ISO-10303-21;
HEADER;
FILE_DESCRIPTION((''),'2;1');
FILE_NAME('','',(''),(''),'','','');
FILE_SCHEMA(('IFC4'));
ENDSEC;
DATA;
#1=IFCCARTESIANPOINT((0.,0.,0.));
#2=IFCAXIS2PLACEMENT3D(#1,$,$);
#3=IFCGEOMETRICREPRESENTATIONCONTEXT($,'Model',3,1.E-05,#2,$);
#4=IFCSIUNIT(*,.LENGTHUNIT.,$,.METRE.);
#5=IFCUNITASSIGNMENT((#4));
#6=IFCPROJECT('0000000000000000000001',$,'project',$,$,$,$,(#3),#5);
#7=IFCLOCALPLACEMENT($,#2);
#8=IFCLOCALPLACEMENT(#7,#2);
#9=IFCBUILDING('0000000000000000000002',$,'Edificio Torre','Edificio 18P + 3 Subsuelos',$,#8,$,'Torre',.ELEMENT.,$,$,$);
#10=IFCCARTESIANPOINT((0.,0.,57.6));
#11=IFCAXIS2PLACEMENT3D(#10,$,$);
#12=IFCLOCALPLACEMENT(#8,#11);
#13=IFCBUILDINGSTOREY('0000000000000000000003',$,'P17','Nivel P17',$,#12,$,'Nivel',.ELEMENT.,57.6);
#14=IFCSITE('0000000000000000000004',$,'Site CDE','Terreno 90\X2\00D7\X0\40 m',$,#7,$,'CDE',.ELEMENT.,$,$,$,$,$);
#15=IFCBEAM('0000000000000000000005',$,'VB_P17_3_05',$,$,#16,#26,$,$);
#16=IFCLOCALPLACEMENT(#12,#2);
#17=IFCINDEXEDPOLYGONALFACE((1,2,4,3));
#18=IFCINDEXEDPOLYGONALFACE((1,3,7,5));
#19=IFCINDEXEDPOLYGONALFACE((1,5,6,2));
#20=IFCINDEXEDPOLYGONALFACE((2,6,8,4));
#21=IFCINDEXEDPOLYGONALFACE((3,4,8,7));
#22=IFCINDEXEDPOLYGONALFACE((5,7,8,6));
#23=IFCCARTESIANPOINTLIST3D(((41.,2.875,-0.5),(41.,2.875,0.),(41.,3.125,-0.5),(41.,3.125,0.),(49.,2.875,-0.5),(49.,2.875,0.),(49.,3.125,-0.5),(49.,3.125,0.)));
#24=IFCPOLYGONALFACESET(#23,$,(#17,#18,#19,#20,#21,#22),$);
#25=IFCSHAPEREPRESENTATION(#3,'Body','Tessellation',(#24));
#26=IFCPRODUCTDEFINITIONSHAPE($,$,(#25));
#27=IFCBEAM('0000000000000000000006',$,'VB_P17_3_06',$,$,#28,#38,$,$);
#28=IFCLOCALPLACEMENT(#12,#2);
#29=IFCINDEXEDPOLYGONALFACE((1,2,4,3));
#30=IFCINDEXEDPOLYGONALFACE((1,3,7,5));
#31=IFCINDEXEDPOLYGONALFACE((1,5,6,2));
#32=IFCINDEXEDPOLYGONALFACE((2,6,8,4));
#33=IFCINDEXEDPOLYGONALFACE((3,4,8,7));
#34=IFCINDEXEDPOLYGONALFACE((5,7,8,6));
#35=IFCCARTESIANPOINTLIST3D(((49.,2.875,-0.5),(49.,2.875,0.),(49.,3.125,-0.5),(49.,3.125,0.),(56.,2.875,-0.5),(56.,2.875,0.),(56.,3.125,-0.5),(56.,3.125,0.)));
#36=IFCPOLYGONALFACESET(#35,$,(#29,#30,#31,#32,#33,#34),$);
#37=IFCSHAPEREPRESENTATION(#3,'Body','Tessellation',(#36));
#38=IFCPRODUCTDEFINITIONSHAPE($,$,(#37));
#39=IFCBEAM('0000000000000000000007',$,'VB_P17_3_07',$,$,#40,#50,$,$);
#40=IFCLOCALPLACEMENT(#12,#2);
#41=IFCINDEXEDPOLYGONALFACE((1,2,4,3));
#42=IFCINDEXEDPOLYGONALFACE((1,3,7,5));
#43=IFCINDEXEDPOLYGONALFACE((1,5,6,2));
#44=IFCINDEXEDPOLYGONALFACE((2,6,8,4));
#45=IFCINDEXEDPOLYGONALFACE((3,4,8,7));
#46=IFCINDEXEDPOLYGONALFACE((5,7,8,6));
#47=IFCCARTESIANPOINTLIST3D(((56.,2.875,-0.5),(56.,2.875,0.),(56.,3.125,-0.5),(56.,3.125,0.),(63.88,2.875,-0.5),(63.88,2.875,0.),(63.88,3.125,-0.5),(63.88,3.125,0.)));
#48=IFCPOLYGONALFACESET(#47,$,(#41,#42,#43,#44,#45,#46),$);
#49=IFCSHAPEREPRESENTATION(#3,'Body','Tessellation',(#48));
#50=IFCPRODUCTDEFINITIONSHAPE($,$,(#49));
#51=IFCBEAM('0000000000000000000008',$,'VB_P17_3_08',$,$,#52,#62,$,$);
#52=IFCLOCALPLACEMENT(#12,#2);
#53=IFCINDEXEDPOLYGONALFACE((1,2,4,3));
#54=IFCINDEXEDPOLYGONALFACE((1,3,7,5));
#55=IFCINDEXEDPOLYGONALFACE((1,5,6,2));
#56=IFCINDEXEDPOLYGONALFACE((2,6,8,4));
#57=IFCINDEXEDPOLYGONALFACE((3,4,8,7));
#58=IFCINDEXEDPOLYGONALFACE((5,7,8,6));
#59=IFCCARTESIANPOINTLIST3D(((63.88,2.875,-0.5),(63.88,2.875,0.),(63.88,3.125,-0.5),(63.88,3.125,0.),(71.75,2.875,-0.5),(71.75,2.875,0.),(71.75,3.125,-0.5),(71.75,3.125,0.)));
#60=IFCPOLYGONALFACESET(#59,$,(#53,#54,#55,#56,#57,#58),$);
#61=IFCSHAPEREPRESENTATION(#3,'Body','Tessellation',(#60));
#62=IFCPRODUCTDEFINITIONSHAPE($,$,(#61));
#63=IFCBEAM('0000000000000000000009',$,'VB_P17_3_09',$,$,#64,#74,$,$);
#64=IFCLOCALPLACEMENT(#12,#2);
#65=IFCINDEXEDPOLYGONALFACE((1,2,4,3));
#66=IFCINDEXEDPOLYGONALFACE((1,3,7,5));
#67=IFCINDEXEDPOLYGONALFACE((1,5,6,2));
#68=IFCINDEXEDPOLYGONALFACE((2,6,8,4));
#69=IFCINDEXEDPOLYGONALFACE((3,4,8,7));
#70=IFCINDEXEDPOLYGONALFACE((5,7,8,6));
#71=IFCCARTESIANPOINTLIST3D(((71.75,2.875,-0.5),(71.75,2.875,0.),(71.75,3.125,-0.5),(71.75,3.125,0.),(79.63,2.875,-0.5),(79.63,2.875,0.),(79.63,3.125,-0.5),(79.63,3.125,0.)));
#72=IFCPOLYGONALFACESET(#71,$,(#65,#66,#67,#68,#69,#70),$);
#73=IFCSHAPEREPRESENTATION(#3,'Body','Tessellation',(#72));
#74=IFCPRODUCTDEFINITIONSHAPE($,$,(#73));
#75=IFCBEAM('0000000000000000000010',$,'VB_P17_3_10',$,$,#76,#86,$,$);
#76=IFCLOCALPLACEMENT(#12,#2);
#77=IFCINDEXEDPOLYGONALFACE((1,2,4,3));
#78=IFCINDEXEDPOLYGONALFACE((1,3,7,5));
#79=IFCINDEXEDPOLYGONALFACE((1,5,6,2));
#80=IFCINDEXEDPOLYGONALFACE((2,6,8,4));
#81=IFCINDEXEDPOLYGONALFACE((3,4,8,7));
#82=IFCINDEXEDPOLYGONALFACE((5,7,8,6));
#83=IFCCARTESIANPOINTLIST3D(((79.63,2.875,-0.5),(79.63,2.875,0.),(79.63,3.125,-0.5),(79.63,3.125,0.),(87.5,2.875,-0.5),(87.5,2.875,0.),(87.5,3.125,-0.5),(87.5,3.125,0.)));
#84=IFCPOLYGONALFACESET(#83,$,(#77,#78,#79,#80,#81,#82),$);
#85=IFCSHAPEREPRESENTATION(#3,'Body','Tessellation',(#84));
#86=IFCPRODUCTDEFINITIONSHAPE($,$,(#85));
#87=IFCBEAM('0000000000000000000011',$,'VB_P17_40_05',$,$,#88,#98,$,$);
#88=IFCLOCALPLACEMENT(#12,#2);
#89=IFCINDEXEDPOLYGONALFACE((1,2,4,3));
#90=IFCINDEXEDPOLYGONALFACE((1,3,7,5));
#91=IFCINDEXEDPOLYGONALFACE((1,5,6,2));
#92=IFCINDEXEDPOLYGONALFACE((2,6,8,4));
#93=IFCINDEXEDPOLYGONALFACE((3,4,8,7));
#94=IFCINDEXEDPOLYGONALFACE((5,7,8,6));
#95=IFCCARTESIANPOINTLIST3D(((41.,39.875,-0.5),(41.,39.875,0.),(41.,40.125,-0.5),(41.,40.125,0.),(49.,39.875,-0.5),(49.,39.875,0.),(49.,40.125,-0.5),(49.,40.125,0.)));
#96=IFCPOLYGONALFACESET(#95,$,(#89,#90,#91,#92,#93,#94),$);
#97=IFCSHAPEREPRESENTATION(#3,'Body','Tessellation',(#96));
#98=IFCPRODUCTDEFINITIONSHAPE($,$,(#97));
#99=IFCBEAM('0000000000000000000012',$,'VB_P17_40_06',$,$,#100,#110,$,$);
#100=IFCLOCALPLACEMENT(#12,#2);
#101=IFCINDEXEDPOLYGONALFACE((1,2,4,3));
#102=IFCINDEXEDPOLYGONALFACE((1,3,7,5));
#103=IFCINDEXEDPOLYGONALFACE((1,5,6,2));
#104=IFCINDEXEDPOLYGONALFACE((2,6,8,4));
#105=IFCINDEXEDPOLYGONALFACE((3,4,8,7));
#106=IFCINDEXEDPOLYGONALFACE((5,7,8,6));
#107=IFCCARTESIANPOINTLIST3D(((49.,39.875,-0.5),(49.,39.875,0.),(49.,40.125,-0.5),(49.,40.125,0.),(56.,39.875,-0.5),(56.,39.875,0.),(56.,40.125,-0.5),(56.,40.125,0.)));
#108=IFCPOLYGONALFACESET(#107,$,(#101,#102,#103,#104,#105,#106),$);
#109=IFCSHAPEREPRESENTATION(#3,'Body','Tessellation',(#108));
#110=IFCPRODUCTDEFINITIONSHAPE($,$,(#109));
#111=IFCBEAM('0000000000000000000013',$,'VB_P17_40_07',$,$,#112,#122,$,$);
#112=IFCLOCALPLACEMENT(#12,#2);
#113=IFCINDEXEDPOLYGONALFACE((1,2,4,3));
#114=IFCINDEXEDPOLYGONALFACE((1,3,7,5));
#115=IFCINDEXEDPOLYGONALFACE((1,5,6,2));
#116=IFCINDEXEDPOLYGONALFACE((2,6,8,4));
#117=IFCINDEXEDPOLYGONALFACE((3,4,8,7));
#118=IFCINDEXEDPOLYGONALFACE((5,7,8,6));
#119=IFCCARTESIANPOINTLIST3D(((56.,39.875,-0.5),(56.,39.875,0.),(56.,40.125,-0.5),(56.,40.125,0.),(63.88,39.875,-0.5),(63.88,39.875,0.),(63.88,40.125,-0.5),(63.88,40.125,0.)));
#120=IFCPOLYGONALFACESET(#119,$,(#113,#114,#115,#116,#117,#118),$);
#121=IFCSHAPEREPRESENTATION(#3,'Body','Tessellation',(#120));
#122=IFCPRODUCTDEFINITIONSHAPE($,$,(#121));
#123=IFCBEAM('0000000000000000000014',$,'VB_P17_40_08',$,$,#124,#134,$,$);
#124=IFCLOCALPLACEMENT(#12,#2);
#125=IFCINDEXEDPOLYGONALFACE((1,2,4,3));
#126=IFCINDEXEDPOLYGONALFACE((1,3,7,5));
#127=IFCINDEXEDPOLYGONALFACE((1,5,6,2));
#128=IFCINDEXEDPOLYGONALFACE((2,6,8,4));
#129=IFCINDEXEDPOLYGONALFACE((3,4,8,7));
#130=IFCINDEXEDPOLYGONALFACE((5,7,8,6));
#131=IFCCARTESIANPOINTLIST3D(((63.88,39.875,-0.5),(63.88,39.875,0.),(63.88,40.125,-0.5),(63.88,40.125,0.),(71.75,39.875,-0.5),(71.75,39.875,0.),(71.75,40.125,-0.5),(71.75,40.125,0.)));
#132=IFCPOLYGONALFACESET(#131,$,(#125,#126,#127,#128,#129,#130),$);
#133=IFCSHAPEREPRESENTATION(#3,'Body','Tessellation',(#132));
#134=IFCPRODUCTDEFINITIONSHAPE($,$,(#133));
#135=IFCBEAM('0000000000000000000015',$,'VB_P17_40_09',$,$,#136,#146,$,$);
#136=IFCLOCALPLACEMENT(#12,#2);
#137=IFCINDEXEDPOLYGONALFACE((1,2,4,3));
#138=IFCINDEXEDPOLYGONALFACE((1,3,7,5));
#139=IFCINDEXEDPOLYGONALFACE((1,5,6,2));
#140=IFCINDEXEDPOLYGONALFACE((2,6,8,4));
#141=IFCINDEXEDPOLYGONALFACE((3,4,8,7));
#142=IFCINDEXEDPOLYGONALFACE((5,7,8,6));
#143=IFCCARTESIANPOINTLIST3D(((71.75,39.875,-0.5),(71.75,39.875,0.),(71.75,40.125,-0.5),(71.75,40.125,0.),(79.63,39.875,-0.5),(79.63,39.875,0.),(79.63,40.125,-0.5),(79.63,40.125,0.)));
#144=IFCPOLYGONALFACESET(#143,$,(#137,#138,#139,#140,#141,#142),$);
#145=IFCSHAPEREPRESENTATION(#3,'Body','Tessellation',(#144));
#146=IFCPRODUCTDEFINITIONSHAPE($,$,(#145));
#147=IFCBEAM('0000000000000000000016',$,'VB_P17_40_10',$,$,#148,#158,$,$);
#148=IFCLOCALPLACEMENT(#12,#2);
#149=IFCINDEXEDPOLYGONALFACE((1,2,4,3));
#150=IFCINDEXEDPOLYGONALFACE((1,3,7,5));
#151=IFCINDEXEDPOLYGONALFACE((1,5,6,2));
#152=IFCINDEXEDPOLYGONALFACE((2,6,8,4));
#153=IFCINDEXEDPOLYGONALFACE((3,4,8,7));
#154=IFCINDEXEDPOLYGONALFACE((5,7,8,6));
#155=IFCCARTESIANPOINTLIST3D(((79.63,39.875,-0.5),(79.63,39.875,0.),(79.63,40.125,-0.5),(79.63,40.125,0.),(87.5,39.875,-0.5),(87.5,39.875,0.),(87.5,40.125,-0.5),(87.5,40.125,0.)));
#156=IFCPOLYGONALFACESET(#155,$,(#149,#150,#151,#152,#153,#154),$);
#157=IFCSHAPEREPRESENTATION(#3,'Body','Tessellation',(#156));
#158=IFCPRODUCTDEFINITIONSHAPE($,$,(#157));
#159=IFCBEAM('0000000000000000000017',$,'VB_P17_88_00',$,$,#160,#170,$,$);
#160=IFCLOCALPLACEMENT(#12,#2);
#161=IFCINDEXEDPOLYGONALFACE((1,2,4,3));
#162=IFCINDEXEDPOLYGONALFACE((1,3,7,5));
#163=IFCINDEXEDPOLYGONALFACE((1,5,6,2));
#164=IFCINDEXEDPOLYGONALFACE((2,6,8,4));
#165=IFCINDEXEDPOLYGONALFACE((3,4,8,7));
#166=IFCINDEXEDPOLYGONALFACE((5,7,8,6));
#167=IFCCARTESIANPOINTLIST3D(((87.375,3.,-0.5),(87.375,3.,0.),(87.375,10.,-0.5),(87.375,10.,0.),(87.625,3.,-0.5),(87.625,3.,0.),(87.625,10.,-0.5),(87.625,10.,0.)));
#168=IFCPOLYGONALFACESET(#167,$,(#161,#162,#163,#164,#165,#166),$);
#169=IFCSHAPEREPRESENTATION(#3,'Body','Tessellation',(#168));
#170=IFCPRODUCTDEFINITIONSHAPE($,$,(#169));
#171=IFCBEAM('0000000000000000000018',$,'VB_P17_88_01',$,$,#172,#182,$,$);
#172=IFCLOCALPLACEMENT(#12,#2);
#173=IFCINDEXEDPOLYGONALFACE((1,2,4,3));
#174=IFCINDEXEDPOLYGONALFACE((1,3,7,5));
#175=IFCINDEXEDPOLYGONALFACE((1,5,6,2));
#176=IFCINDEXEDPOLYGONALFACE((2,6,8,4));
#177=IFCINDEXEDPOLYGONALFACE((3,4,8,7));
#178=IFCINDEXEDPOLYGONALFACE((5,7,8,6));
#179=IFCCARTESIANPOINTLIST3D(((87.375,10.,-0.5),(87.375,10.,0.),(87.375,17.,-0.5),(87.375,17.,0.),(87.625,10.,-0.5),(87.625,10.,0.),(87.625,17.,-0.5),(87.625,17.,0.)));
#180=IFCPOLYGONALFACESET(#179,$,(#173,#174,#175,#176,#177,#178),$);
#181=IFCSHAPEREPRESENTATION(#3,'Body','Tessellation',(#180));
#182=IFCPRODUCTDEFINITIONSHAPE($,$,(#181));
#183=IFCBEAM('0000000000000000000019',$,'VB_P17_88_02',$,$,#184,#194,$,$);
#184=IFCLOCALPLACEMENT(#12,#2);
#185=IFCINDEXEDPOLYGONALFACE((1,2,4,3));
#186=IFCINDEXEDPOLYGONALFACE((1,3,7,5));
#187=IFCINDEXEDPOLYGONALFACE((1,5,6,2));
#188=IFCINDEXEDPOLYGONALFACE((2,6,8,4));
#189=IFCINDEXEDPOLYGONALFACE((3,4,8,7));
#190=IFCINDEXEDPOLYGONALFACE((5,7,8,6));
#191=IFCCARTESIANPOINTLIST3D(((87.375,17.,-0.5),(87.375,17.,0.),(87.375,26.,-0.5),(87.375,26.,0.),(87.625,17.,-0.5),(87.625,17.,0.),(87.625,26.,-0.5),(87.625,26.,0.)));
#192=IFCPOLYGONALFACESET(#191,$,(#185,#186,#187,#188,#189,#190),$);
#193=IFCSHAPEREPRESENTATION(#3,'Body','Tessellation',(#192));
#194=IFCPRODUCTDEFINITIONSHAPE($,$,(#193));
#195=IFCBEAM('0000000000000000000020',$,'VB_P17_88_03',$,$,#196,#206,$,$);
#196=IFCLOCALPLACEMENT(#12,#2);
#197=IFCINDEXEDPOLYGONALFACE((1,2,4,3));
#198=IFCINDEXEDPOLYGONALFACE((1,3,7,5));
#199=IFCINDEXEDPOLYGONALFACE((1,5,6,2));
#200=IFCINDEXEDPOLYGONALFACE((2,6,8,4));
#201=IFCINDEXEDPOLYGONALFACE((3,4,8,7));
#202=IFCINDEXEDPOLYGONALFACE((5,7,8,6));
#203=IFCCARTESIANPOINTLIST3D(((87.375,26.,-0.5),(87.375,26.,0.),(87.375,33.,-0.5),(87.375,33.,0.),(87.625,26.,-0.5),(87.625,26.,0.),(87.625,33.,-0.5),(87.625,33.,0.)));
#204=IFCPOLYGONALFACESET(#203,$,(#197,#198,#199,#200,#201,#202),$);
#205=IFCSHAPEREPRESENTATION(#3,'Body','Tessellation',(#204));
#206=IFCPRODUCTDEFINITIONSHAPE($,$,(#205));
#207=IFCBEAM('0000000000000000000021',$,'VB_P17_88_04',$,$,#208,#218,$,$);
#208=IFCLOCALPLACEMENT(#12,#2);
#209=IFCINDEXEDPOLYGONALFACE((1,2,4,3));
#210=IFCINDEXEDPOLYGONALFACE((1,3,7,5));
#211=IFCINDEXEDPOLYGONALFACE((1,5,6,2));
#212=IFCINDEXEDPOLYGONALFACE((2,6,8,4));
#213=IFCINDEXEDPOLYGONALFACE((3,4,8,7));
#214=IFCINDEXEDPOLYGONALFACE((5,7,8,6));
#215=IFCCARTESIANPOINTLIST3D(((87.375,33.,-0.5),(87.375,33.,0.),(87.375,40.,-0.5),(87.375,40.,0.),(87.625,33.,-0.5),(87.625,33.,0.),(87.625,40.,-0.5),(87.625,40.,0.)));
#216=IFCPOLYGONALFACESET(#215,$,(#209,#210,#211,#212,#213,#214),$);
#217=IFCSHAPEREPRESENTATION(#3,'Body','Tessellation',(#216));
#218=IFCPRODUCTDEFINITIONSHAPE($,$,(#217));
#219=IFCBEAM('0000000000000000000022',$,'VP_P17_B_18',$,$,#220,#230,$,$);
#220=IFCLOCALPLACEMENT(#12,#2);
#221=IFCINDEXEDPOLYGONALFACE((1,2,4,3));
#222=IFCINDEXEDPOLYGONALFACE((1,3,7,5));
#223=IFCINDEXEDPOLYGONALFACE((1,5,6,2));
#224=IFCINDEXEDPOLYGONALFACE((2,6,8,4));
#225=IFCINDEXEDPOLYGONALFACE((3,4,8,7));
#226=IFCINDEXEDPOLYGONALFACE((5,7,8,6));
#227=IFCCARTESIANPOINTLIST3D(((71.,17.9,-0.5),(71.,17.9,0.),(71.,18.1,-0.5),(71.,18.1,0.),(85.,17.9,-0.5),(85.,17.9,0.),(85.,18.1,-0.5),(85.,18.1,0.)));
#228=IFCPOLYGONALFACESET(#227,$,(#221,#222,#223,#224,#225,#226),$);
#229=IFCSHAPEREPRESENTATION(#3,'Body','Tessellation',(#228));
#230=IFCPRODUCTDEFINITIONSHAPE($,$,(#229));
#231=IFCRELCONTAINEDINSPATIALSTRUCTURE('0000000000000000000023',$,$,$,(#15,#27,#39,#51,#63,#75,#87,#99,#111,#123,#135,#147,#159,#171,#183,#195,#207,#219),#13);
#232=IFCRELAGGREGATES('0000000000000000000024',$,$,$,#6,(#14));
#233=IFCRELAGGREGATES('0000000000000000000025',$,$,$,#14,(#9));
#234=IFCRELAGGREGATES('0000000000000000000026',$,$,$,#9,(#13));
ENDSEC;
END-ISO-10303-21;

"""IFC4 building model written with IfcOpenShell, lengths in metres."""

from ifc_helpers import new_model, si_unit, frame, origin, origin_2d, place, context, project, spatial, rectangle, extrude, element, save


model = new_model("IFC4")

# Units and contexts
model_context = context("Model", 3, precision=1e-05, world=origin())
ifc_project = project(units=[si_unit("LENGTHUNIT", "METRE")], contexts=[model_context])

# Site, building, storey
site_placement = place(None, origin())
site = spatial("IfcSite", under=ifc_project, at=site_placement, Name="Site CDE", Description="Terreno 90×40 m", LongName="CDE", CompositionType="ELEMENT")
building_placement = place(site_placement, origin())
building = spatial("IfcBuilding", under=site, at=building_placement, Name="Edificio Torre", Description="Edificio 18P + 3 Subsuelos", LongName="Torre", CompositionType="ELEMENT")
storey_placement = place(building_placement, frame((0.0, 0.0, 57.6)))
storey = spatial("IfcBuildingStorey", under=building, at=storey_placement, Name="P17", Description="Nivel P17", LongName="Nivel", CompositionType="ELEMENT", Elevation=57.6)

# Beams
beam_1_placement = place(storey_placement, frame((45.0, 3.0, -0.5)))
element("IfcBeam", 1, at=beam_1_placement, inside=storey, Name="VB_P17_3_05", context=model_context, shape_type="SweptSolid", body=[
    extrude(rectangle(XDim=8.0, YDim=0.25, at=origin_2d()), origin(), (0.0, 0.0, 1.0), 0.5),
])
beam_2_placement = place(storey_placement, frame((52.5, 3.0, -0.5)))
element("IfcBeam", 2, at=beam_2_placement, inside=storey, Name="VB_P17_3_06", context=model_context, shape_type="SweptSolid", body=[
    extrude(rectangle(XDim=7.0, YDim=0.25, at=origin_2d()), origin(), (0.0, 0.0, 1.0), 0.5),
])
beam_3_placement = place(storey_placement, frame((59.94, 3.0, -0.5)))
element("IfcBeam", 3, at=beam_3_placement, inside=storey, Name="VB_P17_3_07", context=model_context, shape_type="SweptSolid", body=[
    extrude(rectangle(XDim=7.88, YDim=0.25, at=origin_2d()), origin(), (0.0, 0.0, 1.0), 0.5),
])
beam_4_placement = place(storey_placement, frame((67.815, 3.0, -0.5)))
element("IfcBeam", 4, at=beam_4_placement, inside=storey, Name="VB_P17_3_08", context=model_context, shape_type="SweptSolid", body=[
    extrude(rectangle(XDim=7.87, YDim=0.25, at=origin_2d()), origin(), (0.0, 0.0, 1.0), 0.5),
])
beam_5_placement = place(storey_placement, frame((75.69, 3.0, -0.5)))
element("IfcBeam", 5, at=beam_5_placement, inside=storey, Name="VB_P17_3_09", context=model_context, shape_type="SweptSolid", body=[
    extrude(rectangle(XDim=7.88, YDim=0.25, at=origin_2d()), origin(), (0.0, 0.0, 1.0), 0.5),
])
beam_6_placement = place(storey_placement, frame((83.565, 3.0, -0.5)))
element("IfcBeam", 6, at=beam_6_placement, inside=storey, Name="VB_P17_3_10", context=model_context, shape_type="SweptSolid", body=[
    extrude(rectangle(XDim=7.87, YDim=0.25, at=origin_2d()), origin(), (0.0, 0.0, 1.0), 0.5),
])
beam_7_placement = place(storey_placement, frame((45.0, 40.0, -0.5)))
element("IfcBeam", 7, at=beam_7_placement, inside=storey, Name="VB_P17_40_05", context=model_context, shape_type="SweptSolid", body=[
    extrude(rectangle(XDim=8.0, YDim=0.25, at=origin_2d()), origin(), (0.0, 0.0, 1.0), 0.5),
])
beam_8_placement = place(storey_placement, frame((52.5, 40.0, -0.5)))
element("IfcBeam", 8, at=beam_8_placement, inside=storey, Name="VB_P17_40_06", context=model_context, shape_type="SweptSolid", body=[
    extrude(rectangle(XDim=7.0, YDim=0.25, at=origin_2d()), origin(), (0.0, 0.0, 1.0), 0.5),
])
beam_9_placement = place(storey_placement, frame((59.94, 40.0, -0.5)))
element("IfcBeam", 9, at=beam_9_placement, inside=storey, Name="VB_P17_40_07", context=model_context, shape_type="SweptSolid", body=[
    extrude(rectangle(XDim=7.88, YDim=0.25, at=origin_2d()), origin(), (0.0, 0.0, 1.0), 0.5),
])
beam_10_placement = place(storey_placement, frame((67.815, 40.0, -0.5)))
element("IfcBeam", 10, at=beam_10_placement, inside=storey, Name="VB_P17_40_08", context=model_context, shape_type="SweptSolid", body=[
    extrude(rectangle(XDim=7.87, YDim=0.25, at=origin_2d()), origin(), (0.0, 0.0, 1.0), 0.5),
])
beam_11_placement = place(storey_placement, frame((75.69, 40.0, -0.5)))
element("IfcBeam", 11, at=beam_11_placement, inside=storey, Name="VB_P17_40_09", context=model_context, shape_type="SweptSolid", body=[
    extrude(rectangle(XDim=7.88, YDim=0.25, at=origin_2d()), origin(), (0.0, 0.0, 1.0), 0.5),
])
beam_12_placement = place(storey_placement, frame((83.565, 40.0, -0.5)))
element("IfcBeam", 12, at=beam_12_placement, inside=storey, Name="VB_P17_40_10", context=model_context, shape_type="SweptSolid", body=[
    extrude(rectangle(XDim=7.87, YDim=0.25, at=origin_2d()), origin(), (0.0, 0.0, 1.0), 0.5),
])
for number, where, name in (
    (13, (87.5, 6.5, -0.5), "VB_P17_88_00"),
    (14, (87.5, 13.5, -0.5), "VB_P17_88_01"),
):
    element("IfcBeam", number, at=place(storey_placement, frame(where)), inside=storey, Name=name, context=model_context, shape_type="SweptSolid", body=[
        extrude(rectangle(XDim=0.25, YDim=7.0, at=origin_2d()), origin(), (0.0, 0.0, 1.0), 0.5),
    ])
beam_13_placement = place(storey_placement, frame((87.5, 21.5, -0.5)))
element("IfcBeam", 15, at=beam_13_placement, inside=storey, Name="VB_P17_88_02", context=model_context, shape_type="SweptSolid", body=[
    extrude(rectangle(XDim=0.25, YDim=9.0, at=origin_2d()), origin(), (0.0, 0.0, 1.0), 0.5),
])
for number, where, name in (
    (16, (87.5, 29.5, -0.5), "VB_P17_88_03"),
    (17, (87.5, 36.5, -0.5), "VB_P17_88_04"),
):
    element("IfcBeam", number, at=place(storey_placement, frame(where)), inside=storey, Name=name, context=model_context, shape_type="SweptSolid", body=[
        extrude(rectangle(XDim=0.25, YDim=7.0, at=origin_2d()), origin(), (0.0, 0.0, 1.0), 0.5),
    ])
for number, where, name in (
    (18, (78.0, 18.0, -0.5), "VP_P17_B_18"),
):
    element("IfcBeam", number, at=place(storey_placement, frame(where)), inside=storey, Name=name, context=model_context, shape_type="SweptSolid", body=[
        extrude(rectangle(XDim=14.0, YDim=0.2, at=origin_2d()), origin(), (0.0, 0.0, 1.0), 0.5),
    ])

save(model, "model.ifc")
